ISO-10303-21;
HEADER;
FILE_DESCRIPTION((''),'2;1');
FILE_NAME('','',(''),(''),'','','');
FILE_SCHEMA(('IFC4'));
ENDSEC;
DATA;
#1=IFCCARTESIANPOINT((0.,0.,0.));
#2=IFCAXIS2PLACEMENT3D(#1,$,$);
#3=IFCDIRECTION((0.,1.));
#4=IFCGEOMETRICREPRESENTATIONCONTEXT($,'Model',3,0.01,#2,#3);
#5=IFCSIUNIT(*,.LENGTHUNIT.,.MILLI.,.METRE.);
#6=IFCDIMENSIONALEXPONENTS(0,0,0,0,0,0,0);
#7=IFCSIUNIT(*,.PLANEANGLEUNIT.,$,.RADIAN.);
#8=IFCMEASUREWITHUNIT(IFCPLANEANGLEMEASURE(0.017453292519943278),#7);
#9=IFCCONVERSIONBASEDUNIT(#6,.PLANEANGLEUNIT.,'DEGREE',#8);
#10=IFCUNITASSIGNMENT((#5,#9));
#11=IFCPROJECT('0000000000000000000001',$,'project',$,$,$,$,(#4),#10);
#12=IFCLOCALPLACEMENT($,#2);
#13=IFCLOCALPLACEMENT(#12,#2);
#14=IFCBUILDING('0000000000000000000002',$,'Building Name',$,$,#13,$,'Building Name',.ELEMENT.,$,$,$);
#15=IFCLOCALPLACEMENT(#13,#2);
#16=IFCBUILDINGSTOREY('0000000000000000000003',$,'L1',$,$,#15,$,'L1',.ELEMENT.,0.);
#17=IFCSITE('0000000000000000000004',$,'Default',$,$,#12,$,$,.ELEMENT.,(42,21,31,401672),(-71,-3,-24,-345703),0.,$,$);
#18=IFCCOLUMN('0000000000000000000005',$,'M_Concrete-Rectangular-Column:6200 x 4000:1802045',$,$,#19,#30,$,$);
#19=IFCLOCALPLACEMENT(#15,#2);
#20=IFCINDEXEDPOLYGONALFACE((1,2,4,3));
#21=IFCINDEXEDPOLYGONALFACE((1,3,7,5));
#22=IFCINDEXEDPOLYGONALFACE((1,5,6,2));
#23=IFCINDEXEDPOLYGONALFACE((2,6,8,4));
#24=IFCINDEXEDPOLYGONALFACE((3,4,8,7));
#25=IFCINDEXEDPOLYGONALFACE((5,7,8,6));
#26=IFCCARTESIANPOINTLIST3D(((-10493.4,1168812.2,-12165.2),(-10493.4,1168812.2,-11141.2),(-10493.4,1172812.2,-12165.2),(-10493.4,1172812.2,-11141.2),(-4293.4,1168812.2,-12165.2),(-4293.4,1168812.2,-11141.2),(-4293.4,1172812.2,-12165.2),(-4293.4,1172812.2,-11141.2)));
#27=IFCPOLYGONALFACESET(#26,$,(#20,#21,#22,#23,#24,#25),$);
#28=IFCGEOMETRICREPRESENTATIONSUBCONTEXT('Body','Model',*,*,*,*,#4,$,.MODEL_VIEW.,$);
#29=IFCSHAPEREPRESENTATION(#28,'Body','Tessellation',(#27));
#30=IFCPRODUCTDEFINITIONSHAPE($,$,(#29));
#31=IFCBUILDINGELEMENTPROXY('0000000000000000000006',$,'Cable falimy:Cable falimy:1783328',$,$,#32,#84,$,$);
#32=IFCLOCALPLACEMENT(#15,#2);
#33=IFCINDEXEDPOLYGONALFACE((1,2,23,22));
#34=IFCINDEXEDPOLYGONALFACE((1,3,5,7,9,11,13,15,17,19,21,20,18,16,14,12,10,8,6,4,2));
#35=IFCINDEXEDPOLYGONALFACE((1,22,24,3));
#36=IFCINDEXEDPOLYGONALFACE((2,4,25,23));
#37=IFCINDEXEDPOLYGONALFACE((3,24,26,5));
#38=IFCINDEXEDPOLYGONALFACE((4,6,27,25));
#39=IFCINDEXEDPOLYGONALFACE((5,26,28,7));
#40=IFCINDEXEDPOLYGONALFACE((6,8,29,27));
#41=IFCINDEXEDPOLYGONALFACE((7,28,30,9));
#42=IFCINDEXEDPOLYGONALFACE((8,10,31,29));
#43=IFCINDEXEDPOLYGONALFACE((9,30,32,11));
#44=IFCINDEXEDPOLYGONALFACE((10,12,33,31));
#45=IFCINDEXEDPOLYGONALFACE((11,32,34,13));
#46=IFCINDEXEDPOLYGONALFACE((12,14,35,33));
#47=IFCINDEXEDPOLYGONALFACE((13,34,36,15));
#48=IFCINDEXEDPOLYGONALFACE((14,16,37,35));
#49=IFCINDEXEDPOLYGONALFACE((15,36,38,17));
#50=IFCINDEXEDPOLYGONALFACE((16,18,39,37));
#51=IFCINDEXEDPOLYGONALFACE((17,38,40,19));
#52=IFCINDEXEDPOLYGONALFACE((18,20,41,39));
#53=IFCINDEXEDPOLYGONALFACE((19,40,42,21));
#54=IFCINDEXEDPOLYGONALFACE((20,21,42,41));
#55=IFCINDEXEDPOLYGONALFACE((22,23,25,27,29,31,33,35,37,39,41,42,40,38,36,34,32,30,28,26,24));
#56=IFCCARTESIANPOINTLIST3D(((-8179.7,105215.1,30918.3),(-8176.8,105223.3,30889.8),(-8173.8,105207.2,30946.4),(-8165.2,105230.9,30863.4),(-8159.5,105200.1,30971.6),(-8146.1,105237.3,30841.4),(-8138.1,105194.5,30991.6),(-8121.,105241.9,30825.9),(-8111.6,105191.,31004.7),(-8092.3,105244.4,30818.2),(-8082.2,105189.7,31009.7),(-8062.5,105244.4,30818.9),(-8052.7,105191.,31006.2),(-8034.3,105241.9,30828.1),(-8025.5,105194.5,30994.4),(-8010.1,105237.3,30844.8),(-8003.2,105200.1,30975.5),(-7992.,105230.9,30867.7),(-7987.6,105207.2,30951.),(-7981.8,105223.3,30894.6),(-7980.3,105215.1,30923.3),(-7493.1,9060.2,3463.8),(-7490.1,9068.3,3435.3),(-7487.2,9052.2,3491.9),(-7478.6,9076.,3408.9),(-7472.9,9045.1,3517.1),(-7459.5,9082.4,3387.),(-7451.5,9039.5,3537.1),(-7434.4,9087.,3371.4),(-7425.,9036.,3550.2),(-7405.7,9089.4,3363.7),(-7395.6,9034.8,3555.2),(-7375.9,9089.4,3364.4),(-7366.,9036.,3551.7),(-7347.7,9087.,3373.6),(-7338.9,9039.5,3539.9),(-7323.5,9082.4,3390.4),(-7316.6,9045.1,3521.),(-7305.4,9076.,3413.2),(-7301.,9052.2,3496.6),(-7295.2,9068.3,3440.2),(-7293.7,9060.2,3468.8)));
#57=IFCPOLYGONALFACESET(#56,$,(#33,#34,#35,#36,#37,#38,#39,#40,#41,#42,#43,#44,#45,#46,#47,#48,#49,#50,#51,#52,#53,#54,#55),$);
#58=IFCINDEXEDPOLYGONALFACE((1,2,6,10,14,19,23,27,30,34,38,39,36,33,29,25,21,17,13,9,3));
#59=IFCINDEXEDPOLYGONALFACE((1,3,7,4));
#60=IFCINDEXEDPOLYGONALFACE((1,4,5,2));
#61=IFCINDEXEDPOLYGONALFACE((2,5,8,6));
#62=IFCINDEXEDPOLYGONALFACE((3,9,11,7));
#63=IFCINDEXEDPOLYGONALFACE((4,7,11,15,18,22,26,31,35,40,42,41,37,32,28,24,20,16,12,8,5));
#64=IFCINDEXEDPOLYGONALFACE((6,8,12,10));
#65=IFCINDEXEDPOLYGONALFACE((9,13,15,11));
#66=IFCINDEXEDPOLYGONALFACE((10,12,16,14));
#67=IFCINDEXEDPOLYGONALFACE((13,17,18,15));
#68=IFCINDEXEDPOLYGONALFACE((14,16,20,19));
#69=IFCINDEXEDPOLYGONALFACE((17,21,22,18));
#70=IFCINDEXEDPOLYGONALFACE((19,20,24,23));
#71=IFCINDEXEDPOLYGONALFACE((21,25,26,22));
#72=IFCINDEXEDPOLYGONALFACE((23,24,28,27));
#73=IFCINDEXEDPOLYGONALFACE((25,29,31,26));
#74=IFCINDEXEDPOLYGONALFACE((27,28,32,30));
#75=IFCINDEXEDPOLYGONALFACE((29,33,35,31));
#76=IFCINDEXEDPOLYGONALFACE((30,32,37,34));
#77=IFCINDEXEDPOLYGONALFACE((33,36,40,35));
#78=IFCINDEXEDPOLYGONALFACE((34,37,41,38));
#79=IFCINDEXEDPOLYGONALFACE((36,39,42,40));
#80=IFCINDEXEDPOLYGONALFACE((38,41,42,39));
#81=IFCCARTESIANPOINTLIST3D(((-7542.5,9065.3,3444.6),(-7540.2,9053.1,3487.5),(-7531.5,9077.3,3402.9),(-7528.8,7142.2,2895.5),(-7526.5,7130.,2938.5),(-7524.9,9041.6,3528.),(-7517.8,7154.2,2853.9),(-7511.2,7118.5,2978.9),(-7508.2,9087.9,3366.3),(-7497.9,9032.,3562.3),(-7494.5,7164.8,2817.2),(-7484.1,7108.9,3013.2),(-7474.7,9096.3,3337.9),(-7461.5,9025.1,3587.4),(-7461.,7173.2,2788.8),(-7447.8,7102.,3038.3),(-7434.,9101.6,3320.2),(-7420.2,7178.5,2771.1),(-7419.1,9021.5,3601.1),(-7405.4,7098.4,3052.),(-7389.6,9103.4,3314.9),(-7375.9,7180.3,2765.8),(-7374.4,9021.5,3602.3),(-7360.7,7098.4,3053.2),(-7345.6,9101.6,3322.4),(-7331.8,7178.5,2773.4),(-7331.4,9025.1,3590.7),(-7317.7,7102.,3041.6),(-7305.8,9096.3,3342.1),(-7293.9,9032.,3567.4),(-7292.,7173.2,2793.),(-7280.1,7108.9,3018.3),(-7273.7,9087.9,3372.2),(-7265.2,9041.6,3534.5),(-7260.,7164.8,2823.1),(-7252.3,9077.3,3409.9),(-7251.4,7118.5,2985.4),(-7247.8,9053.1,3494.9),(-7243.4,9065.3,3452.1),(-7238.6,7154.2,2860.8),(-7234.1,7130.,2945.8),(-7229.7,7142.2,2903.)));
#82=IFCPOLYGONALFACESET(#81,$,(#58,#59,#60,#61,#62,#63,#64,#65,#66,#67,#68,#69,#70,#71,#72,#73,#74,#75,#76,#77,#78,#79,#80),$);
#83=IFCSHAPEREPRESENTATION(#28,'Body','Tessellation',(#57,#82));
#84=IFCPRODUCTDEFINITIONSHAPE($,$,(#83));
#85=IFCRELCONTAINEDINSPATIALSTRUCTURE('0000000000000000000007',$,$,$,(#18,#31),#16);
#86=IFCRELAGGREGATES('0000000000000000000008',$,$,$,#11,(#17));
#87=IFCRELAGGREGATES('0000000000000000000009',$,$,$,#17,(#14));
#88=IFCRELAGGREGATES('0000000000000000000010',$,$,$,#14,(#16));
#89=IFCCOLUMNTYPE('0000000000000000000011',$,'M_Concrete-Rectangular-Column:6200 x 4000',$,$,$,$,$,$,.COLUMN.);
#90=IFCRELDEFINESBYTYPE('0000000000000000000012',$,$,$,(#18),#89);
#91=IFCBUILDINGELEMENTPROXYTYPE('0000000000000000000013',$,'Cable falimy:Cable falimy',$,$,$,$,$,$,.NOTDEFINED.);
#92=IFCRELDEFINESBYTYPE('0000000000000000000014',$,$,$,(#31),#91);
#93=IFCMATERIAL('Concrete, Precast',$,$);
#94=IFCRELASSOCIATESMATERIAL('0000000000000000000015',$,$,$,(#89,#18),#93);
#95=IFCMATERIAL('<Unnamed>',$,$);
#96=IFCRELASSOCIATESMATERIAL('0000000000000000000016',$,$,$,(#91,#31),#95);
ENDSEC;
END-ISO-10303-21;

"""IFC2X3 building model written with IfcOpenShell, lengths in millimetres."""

from ifc_helpers import new_model, entity, si_unit, converted_unit, direction, frame, frame_2d, origin, place, context, subcontext, project, spatial, rectangle, circle, extrude, source, transform, mapped, material, type_object, type_shapes, element, save


model = new_model("IFC2X3")

# Units and contexts
model_context = context("Model", 3, precision=0.01, world=origin(), true_north=direction((0.0, 1.0)))
body_context = subcontext(model_context, "Body", "Model", "MODEL_VIEW")
ifc_project = project(units=[si_unit("LENGTHUNIT", "METRE", prefix="MILLI"), converted_unit("PLANEANGLEUNIT", "DEGREE", entity("IfcPlaneAngleMeasure", 0.017453292519943278), si_unit("PLANEANGLEUNIT", "RADIAN"), dimensions=[0, 0, 0, 0, 0, 0, 0])], contexts=[model_context])

# Site, building, storey
site_placement = place(None, origin())
site = spatial("IfcSite", under=ifc_project, at=site_placement, Name="Default", CompositionType="ELEMENT", RefLatitude=(42, 21, 31, 401672), RefLongitude=(-71, -3, -24, -345703), RefElevation=0.0)
building_placement = place(site_placement, origin())
building = spatial("IfcBuilding", under=site, at=building_placement, Name="Building Name", LongName="Building Name", CompositionType="ELEMENT")
storey_placement = place(building_placement, origin())
storey = spatial("IfcBuildingStorey", under=building, at=storey_placement, Name="L1", LongName="L1", CompositionType="ELEMENT", Elevation=0.0)

# Column
ifc_material_1 = material(Name="Concrete, Precast")
column_type_1 = type_object("IfcColumnType", Name="M_Concrete-Rectangular-Column:6200 x 4000", PredefinedType="COLUMN", material=ifc_material_1)
shared_shape_1 = source(origin(), body_context, "Body", "SweptSolid", [
    extrude(rectangle(XDim=4000.0, YDim=6200.0, at=frame_2d((0.0, 0.0), x_axis=(1.0, 0.0))), frame((-7393.4, 1170812.2, -12165.2), z_axis=(0.0, 0.0, 1.0), x_axis=(0.0, -1.0, 0.0)), (0.0, 0.0, 1.0), 1024.0),
])
type_shapes(column_type_1, [shared_shape_1])
column_1_placement = place(storey_placement, origin())
element("IfcColumn", 1, at=column_1_placement, inside=storey, type_object=column_type_1, material=ifc_material_1, Name="M_Concrete-Rectangular-Column:6200 x 4000:1802045", context=body_context, shape_type="MappedRepresentation", body=[
    mapped(shared_shape_1, transform((0.0, 0.0, 0.0), scale=1.0)),
])

# Building element proxy
ifc_material_2 = material(Name="<Unnamed>")
building_element_proxy_type_1 = type_object("IfcBuildingElementProxyType", Name="Cable falimy:Cable falimy", PredefinedType="NOTDEFINED", material=ifc_material_2)
shared_shape_2 = source(origin(), body_context, "Body", "SweptSolid", [
    extrude(circle(Radius=100.0, at=frame_2d((0.0, 0.0), x_axis=(1.0, 0.0))), frame((0.0, 0.0, 0.0), z_axis=(0.96155, 0.0, 0.274631), x_axis=(-0.274631, 0.0, 0.96155)), (0.0, 0.0, 1.0), 100000.0),
    extrude(circle(Radius=150.0, at=frame_2d((0.0, 0.0), x_axis=(1.0, 0.0))), frame((-1923.1, 0.0, -549.3), z_axis=(0.96155, 0.0, 0.274631), x_axis=(0.274631, 0.0, -0.96155)), (0.0, 0.0, 1.0), 2000.0),
])
type_shapes(building_element_proxy_type_1, [shared_shape_2])
proxy_1_placement = place(storey_placement, frame((-7393.2, 9062.2, 3459.1), z_axis=(-0.025001, 0.0, 0.999687), x_axis=(0.0, 1.0, 0.0)))
element("IfcBuildingElementProxy", 2, at=proxy_1_placement, inside=storey, type_object=building_element_proxy_type_1, material=ifc_material_2, Name="Cable falimy:Cable falimy:1783328", context=body_context, shape_type="MappedRepresentation", body=[
    mapped(shared_shape_2, transform((0.0, 0.0, 0.0), scale=1.0)),
])

save(model, "model.ifc")
